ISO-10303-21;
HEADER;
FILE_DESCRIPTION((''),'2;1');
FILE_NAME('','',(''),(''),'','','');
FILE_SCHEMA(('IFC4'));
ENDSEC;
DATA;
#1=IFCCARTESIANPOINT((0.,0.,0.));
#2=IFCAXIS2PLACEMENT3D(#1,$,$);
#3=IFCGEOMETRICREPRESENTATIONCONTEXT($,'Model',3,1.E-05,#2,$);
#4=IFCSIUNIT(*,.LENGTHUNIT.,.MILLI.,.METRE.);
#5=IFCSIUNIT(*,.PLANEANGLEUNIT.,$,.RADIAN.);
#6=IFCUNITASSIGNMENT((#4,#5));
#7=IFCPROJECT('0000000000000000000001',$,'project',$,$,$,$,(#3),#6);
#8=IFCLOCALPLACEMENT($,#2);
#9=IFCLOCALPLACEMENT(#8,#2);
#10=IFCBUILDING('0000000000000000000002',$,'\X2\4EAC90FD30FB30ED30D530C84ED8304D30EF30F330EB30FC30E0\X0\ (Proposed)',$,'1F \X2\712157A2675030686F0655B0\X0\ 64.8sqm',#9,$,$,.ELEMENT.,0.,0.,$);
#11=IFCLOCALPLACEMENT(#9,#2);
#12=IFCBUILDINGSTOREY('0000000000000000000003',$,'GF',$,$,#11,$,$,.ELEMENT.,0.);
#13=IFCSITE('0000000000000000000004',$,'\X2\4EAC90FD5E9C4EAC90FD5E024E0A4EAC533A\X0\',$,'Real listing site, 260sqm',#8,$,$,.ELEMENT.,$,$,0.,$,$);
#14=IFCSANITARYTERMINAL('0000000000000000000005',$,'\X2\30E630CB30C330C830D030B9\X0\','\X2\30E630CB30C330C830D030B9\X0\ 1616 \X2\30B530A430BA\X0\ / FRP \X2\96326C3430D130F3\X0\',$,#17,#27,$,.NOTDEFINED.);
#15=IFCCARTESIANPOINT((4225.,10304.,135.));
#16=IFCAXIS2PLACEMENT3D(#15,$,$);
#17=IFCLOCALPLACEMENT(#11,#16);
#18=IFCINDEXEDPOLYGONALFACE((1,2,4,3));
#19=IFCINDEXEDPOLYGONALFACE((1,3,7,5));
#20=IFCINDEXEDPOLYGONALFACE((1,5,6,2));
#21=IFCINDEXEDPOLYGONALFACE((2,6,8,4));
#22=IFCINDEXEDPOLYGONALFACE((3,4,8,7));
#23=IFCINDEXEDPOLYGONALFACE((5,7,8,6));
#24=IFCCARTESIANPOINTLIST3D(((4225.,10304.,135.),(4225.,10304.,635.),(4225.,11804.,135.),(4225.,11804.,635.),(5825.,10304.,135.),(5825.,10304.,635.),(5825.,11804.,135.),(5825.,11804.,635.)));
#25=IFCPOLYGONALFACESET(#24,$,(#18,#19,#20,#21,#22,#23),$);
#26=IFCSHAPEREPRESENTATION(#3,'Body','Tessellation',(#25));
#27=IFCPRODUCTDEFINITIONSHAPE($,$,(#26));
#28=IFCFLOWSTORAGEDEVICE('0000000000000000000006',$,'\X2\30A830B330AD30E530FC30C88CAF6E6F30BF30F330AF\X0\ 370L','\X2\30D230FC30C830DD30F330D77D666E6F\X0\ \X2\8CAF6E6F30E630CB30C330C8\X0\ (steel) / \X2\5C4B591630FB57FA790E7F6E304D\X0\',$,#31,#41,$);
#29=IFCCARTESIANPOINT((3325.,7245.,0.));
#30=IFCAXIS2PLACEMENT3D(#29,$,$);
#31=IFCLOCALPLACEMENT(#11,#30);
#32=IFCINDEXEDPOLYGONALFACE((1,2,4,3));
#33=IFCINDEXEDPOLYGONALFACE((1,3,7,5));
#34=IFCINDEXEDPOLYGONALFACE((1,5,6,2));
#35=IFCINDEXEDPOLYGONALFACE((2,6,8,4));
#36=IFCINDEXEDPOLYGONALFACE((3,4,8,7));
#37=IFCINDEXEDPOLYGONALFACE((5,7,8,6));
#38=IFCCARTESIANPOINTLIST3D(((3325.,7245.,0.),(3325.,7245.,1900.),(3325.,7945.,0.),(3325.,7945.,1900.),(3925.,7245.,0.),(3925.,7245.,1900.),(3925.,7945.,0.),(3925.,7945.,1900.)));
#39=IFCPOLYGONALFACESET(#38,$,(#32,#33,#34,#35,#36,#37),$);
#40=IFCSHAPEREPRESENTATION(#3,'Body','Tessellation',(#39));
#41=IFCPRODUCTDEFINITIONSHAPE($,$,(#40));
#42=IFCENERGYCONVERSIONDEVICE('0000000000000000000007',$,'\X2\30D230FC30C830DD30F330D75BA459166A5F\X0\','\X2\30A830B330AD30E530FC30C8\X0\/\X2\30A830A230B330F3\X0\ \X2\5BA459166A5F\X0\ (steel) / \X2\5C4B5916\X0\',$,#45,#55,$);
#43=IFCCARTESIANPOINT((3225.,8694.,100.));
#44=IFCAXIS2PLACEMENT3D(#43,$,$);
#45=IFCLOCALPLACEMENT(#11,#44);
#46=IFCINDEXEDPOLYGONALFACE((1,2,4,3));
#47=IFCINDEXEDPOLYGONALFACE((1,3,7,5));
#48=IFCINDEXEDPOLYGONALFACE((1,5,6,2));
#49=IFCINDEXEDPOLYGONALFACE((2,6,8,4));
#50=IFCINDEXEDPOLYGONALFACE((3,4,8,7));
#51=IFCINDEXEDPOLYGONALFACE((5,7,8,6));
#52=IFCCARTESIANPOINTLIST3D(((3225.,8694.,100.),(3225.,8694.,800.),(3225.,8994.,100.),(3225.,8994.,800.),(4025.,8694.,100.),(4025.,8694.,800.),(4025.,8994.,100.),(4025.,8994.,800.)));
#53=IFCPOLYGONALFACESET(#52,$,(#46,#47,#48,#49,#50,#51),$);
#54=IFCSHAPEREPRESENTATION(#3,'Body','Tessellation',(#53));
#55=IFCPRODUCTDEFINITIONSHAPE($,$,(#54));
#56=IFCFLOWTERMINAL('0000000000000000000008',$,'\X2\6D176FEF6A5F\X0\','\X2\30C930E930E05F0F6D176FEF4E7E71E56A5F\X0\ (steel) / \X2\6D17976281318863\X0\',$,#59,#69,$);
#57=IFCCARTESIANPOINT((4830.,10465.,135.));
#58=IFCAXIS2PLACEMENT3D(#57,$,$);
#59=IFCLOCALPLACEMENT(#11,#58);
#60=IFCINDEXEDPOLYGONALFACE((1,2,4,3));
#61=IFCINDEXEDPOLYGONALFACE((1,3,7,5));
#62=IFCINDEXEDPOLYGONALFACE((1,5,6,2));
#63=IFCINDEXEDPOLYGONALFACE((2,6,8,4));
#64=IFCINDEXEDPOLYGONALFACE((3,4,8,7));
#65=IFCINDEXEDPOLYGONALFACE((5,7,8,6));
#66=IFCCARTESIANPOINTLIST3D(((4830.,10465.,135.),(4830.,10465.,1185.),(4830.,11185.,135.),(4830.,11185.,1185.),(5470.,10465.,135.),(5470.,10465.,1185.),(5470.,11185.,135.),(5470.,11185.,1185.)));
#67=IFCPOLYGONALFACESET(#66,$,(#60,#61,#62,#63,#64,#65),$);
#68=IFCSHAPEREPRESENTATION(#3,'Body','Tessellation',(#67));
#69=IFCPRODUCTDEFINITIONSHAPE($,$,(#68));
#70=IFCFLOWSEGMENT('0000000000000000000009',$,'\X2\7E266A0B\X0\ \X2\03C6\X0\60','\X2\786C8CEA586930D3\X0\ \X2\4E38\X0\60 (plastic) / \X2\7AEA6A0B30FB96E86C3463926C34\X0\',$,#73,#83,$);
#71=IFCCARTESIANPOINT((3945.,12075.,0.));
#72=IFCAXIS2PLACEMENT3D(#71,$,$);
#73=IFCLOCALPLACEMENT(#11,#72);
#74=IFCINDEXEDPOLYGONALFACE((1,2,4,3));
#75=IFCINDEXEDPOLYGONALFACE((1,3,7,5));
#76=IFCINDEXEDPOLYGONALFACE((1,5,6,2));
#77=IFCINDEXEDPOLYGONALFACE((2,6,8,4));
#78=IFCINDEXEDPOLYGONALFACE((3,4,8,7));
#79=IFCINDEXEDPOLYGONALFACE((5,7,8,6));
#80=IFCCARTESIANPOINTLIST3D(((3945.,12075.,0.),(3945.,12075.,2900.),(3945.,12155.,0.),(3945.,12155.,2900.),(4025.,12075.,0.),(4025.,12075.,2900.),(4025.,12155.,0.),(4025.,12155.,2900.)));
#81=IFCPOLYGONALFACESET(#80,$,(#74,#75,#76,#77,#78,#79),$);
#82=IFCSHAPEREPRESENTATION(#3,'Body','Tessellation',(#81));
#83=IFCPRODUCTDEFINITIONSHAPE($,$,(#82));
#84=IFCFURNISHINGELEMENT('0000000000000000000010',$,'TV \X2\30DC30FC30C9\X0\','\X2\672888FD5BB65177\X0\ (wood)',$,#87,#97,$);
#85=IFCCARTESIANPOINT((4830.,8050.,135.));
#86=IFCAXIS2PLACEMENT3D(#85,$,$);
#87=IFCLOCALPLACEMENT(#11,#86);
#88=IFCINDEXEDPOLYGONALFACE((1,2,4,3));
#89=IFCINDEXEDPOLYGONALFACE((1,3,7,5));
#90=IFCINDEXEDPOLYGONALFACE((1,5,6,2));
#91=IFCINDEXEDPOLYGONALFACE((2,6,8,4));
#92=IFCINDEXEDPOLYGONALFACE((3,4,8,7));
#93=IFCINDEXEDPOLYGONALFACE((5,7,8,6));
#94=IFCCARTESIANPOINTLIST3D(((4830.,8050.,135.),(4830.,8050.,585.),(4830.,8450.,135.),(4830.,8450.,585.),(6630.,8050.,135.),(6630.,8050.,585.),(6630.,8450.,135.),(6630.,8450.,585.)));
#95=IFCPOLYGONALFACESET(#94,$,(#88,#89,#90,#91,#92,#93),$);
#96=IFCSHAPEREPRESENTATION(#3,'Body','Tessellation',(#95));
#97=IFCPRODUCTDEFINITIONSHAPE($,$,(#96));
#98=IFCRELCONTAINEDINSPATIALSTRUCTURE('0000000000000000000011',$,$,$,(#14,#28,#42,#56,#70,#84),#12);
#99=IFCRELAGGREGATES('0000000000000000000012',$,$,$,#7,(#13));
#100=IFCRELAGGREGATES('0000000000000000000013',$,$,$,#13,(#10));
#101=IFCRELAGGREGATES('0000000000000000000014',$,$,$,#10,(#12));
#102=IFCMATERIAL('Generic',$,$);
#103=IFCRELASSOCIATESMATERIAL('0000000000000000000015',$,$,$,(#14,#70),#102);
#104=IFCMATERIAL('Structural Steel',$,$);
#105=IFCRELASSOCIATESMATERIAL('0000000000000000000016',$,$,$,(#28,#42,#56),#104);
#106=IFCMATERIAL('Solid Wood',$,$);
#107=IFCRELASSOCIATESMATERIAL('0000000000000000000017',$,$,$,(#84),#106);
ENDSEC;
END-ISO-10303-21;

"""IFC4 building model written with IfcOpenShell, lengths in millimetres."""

from ifc_helpers import new_model, si_unit, frame, frame_2d, origin, place, context, project, spatial, rectangle, extrude, material, element, save


model = new_model("IFC4")

# Units and contexts
model_context = context("Model", 3, precision=1e-05, world=origin())
ifc_project = project(units=[si_unit("LENGTHUNIT", "METRE", prefix="MILLI"), si_unit("PLANEANGLEUNIT", "RADIAN")], contexts=[model_context])

# Site, building, storey
site_placement = place(None, origin())
site = spatial("IfcSite", under=ifc_project, at=site_placement, Name="京都府京都市上京区", ObjectType="Real listing site, 260sqm", CompositionType="ELEMENT", RefElevation=0.0)
building_placement = place(site_placement, origin())
building = spatial("IfcBuilding", under=site, at=building_placement, Name="京都・ロフト付きワンルーム (Proposed)", ObjectType="1F 無垢材と漆喰 64.8sqm", CompositionType="ELEMENT", ElevationOfRefHeight=0.0, ElevationOfTerrain=0.0)
storey_placement = place(building_placement, origin())
storey = spatial("IfcBuildingStorey", under=building, at=storey_placement, Name="GF", CompositionType="ELEMENT", Elevation=0.0)

# Shared definitions
ifc_material_1 = material(Name="Solid Wood")

# Shared definitions
ifc_material_2 = material(Name="Structural Steel")

# Sanitary terminal
ifc_material_3 = material(Name="Generic")
sanitary_terminal_placement = place(storey_placement, frame((4225.0, 10304.0, 135.0)))
element("IfcSanitaryTerminal", 1, at=sanitary_terminal_placement, inside=storey, material=ifc_material_3, Name="ユニットバス", Description="ユニットバス 1616 サイズ / FRP 防水パン", PredefinedType="NOTDEFINED", context=model_context, shape_type="SweptSolid", body=[
    extrude(rectangle(XDim=1600.0, YDim=1500.0, at=frame_2d((800.0, 750.0))), frame((4225.0, 10304.0, 135.0)), (0.0, 0.0, 1.0), 500.0),
])

# Flow storage device
flow_storage_device_placement = place(storey_placement, frame((3325.0, 7245.0, 0.0)))
element("IfcFlowStorageDevice", 2, at=flow_storage_device_placement, inside=storey, material=ifc_material_2, Name="エコキュート貯湯タンク 370L", Description="ヒートポンプ給湯 貯湯ユニット (steel) / 屋外・基礎置き", context=model_context, shape_type="SweptSolid", body=[
    extrude(rectangle(XDim=600.0, YDim=700.0, at=frame_2d((300.0, 350.0))), frame((3325.0, 7245.0, 0.0)), (0.0, 0.0, 1.0), 1900.0),
])

# Energy conversion device
energy_conversion_device_placement = place(storey_placement, frame((3225.0, 8694.0, 100.0)))
element("IfcEnergyConversionDevice", 3, at=energy_conversion_device_placement, inside=storey, material=ifc_material_2, Name="ヒートポンプ室外機", Description="エコキュート/エアコン 室外機 (steel) / 屋外", context=model_context, shape_type="SweptSolid", body=[
    extrude(rectangle(XDim=800.0, YDim=300.0, at=frame_2d((400.0, 150.0))), frame((3225.0, 8694.0, 100.0)), (0.0, 0.0, 1.0), 700.0),
])

# Flow terminal
flow_terminal_placement = place(storey_placement, frame((4830.0, 10465.0, 135.0)))
element("IfcFlowTerminal", 4, at=flow_terminal_placement, inside=storey, material=ifc_material_2, Name="洗濯機", Description="ドラム式洗濯乾燥機 (steel) / 洗面脱衣", context=model_context, shape_type="SweptSolid", body=[
    extrude(rectangle(XDim=640.0, YDim=720.0, at=frame_2d((320.0, 360.0))), frame((4830.0, 10465.0, 135.0)), (0.0, 0.0, 1.0), 1050.0),
])

# Flow segment
flow_segment_1_placement = place(storey_placement, frame((3945.0, 12075.0, 0.0)))
element("IfcFlowSegment", 5, at=flow_segment_1_placement, inside=storey, material=ifc_material_3, Name="縦樋 φ60", Description="硬質塩ビ 丸60 (plastic) / 竪樋・雨水排水", context=model_context, shape_type="SweptSolid", body=[
    extrude(rectangle(XDim=80.0, YDim=80.0, at=frame_2d((40.0, 40.0))), frame((3945.0, 12075.0, 0.0)), (0.0, 0.0, 1.0), 2900.0),
])

# Furnishing element
furnishing_placement = place(storey_placement, frame((4830.0, 8050.0, 135.0)))
element("IfcFurnishingElement", 6, at=furnishing_placement, inside=storey, material=ifc_material_1, Name="TV ボード", Description="木製家具 (wood)", context=model_context, shape_type="SweptSolid", body=[
    extrude(rectangle(XDim=1800.0, YDim=400.0, at=frame_2d((900.0, 200.0))), frame((4830.0, 8050.0, 135.0)), (0.0, 0.0, 1.0), 450.0),
])

save(model, "model.ifc")
